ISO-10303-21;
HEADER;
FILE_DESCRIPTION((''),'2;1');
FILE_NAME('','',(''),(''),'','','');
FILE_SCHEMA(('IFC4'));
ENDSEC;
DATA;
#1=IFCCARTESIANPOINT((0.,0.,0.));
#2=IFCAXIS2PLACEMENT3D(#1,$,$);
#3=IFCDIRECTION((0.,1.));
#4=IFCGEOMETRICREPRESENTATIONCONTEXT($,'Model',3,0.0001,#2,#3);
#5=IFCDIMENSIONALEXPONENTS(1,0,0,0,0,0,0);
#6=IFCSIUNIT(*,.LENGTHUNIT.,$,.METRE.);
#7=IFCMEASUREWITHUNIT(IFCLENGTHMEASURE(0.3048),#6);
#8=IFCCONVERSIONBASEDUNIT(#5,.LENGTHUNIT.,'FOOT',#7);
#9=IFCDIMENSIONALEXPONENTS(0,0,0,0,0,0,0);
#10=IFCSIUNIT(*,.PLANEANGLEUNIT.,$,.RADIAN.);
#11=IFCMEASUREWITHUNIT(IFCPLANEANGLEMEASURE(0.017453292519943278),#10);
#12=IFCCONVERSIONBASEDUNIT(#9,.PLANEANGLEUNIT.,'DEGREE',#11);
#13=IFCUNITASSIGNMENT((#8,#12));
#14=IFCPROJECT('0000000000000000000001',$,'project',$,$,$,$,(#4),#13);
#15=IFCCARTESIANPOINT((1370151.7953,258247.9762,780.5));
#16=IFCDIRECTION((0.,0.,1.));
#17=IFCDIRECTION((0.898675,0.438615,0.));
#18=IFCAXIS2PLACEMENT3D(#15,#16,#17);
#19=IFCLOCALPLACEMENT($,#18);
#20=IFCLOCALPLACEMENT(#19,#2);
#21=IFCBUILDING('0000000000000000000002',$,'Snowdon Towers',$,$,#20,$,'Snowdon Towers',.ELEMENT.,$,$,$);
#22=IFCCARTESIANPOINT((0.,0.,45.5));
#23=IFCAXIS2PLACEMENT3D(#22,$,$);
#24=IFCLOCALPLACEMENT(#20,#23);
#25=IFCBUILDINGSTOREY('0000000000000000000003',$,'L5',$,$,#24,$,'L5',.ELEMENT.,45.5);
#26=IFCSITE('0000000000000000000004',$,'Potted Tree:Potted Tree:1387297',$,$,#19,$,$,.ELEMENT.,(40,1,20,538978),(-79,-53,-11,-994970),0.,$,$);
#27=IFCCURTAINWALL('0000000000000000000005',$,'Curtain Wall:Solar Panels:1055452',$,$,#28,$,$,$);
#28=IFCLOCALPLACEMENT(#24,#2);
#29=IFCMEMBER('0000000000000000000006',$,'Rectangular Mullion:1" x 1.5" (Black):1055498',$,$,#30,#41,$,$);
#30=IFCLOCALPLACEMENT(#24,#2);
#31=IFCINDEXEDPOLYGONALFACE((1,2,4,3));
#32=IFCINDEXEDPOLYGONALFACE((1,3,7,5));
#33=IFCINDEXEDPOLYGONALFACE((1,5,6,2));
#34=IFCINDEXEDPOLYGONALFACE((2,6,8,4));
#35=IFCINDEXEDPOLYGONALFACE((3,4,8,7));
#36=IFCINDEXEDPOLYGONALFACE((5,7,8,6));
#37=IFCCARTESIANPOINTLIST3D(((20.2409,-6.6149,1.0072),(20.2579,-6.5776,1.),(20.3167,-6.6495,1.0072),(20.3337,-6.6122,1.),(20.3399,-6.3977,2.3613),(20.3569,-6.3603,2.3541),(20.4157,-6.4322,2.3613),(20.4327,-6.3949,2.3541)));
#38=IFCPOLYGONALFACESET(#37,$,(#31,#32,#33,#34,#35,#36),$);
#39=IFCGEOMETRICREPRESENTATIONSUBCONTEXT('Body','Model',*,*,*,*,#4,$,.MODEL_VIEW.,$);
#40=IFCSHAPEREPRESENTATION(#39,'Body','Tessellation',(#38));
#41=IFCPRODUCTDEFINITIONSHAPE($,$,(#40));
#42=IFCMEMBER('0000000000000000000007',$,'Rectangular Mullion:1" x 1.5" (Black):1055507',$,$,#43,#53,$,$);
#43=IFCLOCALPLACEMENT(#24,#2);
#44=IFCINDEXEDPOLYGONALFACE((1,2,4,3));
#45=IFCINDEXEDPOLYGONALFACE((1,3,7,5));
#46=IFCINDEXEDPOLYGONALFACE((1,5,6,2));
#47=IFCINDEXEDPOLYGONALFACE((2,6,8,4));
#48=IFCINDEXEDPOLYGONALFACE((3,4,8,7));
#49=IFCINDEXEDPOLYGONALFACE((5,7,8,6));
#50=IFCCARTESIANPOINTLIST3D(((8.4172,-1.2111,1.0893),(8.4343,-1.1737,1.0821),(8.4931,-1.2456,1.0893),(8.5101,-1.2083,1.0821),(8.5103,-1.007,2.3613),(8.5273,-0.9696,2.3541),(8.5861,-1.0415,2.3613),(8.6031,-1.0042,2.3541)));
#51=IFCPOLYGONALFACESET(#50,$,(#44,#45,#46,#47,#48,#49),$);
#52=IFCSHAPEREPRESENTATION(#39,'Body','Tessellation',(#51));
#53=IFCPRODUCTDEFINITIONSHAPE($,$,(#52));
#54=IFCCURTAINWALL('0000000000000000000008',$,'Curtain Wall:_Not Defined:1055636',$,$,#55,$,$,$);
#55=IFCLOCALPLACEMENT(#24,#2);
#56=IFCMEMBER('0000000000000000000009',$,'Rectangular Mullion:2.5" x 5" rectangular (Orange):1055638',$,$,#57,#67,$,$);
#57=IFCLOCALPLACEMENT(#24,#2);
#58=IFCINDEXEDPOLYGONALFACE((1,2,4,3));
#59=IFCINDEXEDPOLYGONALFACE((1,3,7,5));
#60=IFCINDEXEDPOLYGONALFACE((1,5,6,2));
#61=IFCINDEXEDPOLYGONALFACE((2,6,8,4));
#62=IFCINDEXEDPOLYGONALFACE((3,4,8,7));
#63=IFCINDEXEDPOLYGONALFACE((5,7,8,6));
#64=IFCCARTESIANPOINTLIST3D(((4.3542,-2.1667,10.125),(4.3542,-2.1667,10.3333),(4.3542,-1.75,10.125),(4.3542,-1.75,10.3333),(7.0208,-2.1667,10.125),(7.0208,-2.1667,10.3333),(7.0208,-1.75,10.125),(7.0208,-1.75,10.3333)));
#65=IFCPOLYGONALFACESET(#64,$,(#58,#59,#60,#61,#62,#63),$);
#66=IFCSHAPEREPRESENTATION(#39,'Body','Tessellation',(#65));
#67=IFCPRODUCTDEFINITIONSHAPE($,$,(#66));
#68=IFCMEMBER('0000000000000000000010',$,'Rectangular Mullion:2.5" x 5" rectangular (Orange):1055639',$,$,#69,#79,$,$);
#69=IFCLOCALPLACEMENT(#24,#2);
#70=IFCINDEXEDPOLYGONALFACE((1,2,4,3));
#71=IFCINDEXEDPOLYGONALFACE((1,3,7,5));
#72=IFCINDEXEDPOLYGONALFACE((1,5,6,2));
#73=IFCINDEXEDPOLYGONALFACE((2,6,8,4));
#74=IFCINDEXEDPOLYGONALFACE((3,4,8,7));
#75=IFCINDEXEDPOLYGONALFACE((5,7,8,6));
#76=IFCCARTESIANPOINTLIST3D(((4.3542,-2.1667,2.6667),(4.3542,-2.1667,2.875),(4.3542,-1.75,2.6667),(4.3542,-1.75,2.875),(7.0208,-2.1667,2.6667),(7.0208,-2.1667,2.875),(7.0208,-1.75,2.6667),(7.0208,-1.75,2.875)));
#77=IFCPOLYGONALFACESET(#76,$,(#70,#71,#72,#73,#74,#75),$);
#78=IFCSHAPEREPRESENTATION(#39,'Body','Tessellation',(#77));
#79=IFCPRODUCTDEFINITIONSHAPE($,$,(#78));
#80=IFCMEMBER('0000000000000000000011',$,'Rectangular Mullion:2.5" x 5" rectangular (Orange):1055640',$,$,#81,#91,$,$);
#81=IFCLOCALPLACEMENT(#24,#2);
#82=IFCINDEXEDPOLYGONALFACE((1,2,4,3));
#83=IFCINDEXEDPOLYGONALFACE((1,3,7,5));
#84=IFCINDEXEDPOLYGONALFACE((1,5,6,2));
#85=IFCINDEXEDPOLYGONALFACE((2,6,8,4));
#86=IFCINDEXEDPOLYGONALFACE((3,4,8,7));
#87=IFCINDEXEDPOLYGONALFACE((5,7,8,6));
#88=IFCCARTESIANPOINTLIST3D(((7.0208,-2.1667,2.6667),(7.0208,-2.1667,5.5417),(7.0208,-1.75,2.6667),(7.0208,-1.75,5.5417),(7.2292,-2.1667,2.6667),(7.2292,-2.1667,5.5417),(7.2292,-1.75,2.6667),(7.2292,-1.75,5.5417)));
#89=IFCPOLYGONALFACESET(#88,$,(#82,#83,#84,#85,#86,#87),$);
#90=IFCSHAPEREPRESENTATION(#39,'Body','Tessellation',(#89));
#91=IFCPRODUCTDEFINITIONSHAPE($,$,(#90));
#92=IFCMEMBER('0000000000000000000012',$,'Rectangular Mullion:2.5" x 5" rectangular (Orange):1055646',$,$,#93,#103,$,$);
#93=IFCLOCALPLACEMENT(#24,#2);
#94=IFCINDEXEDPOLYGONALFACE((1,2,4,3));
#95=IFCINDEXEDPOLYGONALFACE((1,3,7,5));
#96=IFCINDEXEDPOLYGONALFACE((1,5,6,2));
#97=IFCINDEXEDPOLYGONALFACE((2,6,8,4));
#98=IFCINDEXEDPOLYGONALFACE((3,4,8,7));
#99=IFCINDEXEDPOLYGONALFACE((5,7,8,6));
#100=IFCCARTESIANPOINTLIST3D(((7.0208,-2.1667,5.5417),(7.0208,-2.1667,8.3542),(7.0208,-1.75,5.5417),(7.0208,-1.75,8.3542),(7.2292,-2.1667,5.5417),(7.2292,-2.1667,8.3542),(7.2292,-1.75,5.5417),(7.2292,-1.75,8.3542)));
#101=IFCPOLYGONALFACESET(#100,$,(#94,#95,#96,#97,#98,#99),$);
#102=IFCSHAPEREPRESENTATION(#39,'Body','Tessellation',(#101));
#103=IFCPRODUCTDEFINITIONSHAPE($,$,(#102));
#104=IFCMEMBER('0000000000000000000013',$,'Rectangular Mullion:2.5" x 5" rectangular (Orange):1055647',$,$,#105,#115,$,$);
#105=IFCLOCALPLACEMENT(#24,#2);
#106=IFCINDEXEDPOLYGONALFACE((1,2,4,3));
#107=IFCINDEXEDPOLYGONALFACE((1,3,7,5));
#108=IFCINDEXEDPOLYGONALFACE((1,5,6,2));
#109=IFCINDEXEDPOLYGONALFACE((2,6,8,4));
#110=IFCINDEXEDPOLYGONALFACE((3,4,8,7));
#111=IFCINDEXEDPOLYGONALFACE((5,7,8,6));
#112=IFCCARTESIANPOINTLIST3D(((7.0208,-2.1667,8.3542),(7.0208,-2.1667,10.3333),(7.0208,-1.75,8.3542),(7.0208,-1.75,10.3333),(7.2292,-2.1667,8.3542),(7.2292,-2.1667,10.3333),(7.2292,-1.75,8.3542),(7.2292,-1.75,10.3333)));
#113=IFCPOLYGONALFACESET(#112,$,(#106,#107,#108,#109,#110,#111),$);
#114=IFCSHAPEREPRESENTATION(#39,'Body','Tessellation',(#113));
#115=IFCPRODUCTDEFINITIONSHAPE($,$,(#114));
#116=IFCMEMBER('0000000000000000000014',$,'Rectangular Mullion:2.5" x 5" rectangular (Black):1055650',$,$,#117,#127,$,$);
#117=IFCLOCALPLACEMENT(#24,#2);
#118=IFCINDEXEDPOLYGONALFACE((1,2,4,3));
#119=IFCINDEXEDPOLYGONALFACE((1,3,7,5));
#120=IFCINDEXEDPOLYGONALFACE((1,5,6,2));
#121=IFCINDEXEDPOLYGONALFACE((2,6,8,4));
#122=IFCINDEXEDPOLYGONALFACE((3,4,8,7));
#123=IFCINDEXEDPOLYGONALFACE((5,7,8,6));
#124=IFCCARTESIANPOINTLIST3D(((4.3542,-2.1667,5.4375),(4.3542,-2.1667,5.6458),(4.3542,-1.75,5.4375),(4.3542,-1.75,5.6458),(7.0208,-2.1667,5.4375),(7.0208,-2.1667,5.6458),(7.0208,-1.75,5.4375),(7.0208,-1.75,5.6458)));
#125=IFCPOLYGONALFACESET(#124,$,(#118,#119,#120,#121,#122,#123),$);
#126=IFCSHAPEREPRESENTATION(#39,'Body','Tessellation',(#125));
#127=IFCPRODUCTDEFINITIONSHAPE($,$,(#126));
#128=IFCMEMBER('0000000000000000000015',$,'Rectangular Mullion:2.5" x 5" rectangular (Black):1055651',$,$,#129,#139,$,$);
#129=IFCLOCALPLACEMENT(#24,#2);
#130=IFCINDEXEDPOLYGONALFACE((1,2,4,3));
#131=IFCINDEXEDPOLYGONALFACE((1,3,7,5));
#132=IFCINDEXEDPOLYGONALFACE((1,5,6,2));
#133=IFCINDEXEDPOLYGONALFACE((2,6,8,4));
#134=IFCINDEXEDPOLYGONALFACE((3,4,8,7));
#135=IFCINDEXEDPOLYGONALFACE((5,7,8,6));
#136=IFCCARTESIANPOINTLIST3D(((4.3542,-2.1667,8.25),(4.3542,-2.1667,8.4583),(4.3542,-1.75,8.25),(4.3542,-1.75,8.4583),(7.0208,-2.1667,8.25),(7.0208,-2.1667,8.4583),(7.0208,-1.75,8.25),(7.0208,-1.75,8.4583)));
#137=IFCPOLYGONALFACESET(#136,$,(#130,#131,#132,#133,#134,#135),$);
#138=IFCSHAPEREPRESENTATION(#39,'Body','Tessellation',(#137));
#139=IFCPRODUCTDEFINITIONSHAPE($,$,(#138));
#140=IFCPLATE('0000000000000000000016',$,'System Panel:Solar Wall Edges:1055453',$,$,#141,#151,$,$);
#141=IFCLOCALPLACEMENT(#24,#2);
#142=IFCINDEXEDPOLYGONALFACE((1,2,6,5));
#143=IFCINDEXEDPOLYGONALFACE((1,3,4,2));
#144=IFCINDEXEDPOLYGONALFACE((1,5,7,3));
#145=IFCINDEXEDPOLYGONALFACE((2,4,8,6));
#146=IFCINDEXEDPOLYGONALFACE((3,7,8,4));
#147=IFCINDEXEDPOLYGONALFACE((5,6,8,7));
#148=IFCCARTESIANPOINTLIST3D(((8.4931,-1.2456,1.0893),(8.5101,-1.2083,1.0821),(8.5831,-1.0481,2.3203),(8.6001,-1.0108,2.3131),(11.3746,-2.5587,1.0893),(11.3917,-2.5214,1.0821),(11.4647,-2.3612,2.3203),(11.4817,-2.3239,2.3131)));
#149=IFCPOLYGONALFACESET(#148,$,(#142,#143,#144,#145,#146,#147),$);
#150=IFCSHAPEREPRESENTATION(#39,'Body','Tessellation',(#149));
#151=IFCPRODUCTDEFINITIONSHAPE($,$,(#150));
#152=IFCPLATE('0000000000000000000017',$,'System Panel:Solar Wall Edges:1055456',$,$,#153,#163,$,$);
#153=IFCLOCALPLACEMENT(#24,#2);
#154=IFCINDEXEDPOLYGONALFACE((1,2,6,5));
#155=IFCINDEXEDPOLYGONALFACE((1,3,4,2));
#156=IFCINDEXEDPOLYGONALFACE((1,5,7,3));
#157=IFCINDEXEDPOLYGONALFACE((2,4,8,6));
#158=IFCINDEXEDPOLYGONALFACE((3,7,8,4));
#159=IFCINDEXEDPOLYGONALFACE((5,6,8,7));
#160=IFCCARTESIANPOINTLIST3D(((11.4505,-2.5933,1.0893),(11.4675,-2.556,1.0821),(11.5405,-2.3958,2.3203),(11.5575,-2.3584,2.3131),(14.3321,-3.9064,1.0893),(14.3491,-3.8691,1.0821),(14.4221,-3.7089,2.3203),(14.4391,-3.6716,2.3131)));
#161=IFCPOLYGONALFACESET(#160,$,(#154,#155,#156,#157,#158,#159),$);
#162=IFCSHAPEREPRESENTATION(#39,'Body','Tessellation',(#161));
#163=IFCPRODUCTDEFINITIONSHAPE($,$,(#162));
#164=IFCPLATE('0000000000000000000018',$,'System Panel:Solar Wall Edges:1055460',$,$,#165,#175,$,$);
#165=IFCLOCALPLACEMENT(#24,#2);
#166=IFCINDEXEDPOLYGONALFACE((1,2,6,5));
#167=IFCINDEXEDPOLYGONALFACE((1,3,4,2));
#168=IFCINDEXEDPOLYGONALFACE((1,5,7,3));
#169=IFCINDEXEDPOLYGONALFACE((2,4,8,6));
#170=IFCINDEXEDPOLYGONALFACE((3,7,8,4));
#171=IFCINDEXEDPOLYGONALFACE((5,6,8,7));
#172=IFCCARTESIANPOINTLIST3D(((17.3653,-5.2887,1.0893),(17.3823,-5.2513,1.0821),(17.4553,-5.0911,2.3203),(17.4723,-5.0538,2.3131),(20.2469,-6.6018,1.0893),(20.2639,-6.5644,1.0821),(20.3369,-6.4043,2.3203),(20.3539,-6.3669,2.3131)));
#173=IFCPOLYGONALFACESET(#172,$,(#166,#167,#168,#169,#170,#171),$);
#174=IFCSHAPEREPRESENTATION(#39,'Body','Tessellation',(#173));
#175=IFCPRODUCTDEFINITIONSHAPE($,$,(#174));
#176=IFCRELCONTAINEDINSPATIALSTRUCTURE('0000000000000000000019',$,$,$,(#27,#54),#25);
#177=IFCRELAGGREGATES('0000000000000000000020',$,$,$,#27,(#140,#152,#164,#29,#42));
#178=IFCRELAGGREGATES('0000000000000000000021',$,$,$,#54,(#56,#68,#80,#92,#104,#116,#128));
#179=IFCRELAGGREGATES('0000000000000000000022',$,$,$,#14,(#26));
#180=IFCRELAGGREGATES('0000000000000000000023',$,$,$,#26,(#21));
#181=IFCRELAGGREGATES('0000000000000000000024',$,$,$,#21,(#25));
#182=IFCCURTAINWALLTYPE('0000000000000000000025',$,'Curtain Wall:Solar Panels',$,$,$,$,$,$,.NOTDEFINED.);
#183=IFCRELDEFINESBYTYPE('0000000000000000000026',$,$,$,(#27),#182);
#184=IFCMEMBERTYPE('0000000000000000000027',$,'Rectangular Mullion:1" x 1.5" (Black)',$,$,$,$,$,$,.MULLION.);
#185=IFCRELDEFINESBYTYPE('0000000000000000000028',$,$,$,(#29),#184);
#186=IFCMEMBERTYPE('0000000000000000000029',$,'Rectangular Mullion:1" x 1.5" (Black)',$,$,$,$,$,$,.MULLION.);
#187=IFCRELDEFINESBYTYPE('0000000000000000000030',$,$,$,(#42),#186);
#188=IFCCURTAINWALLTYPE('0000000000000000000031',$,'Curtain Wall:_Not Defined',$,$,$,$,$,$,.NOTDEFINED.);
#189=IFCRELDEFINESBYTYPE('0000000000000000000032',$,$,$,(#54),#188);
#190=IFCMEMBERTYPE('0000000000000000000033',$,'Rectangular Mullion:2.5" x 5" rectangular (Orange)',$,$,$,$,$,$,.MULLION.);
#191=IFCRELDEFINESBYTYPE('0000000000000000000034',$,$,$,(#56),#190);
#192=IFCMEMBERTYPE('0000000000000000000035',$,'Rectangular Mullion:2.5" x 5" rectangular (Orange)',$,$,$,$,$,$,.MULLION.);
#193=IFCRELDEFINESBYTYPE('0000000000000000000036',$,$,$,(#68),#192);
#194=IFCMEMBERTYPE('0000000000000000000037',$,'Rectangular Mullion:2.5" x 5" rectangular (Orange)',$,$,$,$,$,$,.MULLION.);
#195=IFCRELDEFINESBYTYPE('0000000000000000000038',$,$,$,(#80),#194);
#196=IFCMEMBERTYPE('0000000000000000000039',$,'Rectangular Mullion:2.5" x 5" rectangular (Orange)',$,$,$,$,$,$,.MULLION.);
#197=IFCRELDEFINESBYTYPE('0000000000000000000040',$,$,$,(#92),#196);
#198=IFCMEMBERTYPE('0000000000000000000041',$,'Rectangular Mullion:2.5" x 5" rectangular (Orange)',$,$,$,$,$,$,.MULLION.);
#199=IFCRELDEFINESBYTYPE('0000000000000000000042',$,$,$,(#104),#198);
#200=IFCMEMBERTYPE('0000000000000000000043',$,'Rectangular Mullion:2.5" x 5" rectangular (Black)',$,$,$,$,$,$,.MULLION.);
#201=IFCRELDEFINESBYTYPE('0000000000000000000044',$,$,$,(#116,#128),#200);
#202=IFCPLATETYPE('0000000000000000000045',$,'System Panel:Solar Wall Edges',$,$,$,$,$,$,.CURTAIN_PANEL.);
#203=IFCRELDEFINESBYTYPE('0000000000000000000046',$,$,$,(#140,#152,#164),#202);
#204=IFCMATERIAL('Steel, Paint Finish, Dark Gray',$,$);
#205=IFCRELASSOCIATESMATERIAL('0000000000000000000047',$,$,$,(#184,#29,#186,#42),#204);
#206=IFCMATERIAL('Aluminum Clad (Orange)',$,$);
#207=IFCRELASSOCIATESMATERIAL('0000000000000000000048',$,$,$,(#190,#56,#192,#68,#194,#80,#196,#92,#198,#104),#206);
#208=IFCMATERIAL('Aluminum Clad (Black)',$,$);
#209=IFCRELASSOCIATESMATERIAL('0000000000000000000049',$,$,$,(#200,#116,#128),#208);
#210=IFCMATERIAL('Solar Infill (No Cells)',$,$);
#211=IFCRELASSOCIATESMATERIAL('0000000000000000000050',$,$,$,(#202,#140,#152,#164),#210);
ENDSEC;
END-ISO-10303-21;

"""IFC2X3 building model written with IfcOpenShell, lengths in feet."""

from ifc_helpers import new_model, entity, si_unit, converted_unit, direction, frame, frame_2d, origin, origin_2d_with_axis, place, context, subcontext, project, spatial, rectangle, extrude, source, transform, mapped, material, type_object, type_shapes, element, aggregate, save


model = new_model("IFC2X3")

# Units and contexts
model_context = context("Model", 3, precision=0.0001, world=origin(), true_north=direction((0.0, 1.0)))
body_context = subcontext(model_context, "Body", "Model", "MODEL_VIEW")
ifc_project = project(units=[converted_unit("LENGTHUNIT", "FOOT", entity("IfcLengthMeasure", 0.3048), si_unit("LENGTHUNIT", "METRE"), dimensions=[1, 0, 0, 0, 0, 0, 0]), converted_unit("PLANEANGLEUNIT", "DEGREE", entity("IfcPlaneAngleMeasure", 0.017453292519943278), si_unit("PLANEANGLEUNIT", "RADIAN"), dimensions=[0, 0, 0, 0, 0, 0, 0])], contexts=[model_context])

# Site, building, storey
site_placement = place(None, frame((1370151.7953, 258247.9762, 780.5), z_axis=(0.0, 0.0, 1.0), x_axis=(0.898675, 0.438615, 0.0)))
site = spatial("IfcSite", under=ifc_project, at=site_placement, Name="Potted Tree:Potted Tree:1387297", CompositionType="ELEMENT", RefLatitude=(40, 1, 20, 538978), RefLongitude=(-79, -53, -11, -994970), RefElevation=0.0)
building_placement = place(site_placement, origin())
building = spatial("IfcBuilding", under=site, at=building_placement, Name="Snowdon Towers", LongName="Snowdon Towers", CompositionType="ELEMENT")
storey_placement = place(building_placement, frame((0.0, 0.0, 45.5)))
storey = spatial("IfcBuildingStorey", under=building, at=storey_placement, Name="L5", LongName="L5", CompositionType="ELEMENT", Elevation=45.5)

# Curtain walls, members
curtain_wall_type_1 = type_object("IfcCurtainWallType", Name="Curtain Wall:Solar Panels", PredefinedType="NOTDEFINED")
curtain_wall_1_placement = place(storey_placement, frame((0.0, 0.0, -45.5)))
curtain_wall_1 = element("IfcCurtainWall", 1, at=curtain_wall_1_placement, inside=storey, type_object=curtain_wall_type_1, Name="Curtain Wall:Solar Panels:1055452")
ifc_material_1 = material(Name="Steel, Paint Finish, Dark Gray")
ifc_material_2 = material(Name="Aluminum Clad (Orange)")
member_type_1 = type_object("IfcMemberType", Name="Rectangular Mullion:1\" x 1.5\" (Black)", PredefinedType="MULLION", material=ifc_material_1)
shared_shape_1 = source(origin(), body_context, "Body", "SweptSolid", [
    extrude(rectangle(XDim=0.0833, YDim=0.0417, at=frame_2d((0.0, 0.0), x_axis=(1.0, 0.0))), frame((-0.0417, 0.0208, -1.375), z_axis=(0.0, 0.0, 1.0), x_axis=(-1.0, 0.0, 0.0)), (0.0, 0.0, 1.0), 1.375),
])
type_shapes(member_type_1, [shared_shape_1])
member_1_placement = place(curtain_wall_1_placement, frame((20.3337, -6.6122, 46.5), z_axis=(-0.072007, -0.158015, -0.984808), x_axis=(0.909972, -0.414671, 0.0)))
member_1 = element("IfcMember", 2, at=member_1_placement, type_object=member_type_1, material=ifc_material_1, Name="Rectangular Mullion:1\" x 1.5\" (Black):1055498", context=body_context, shape_type="MappedRepresentation", body=[
    mapped(shared_shape_1, transform((0.0, 0.0, 0.0), scale=1.0)),
])
member_type_2 = type_object("IfcMemberType", Name="Rectangular Mullion:1\" x 1.5\" (Black)", PredefinedType="MULLION", material=ifc_material_1)
shared_shape_2 = source(origin(), body_context, "Body", "SweptSolid", [
    extrude(rectangle(XDim=0.0833, YDim=0.0417, at=origin_2d_with_axis()), frame((-0.0417, 0.0208, -1.2917), z_axis=(0.0, 0.0, 1.0), x_axis=(-1.0, 0.0, 0.0)), (0.0, 0.0, 1.0), 1.2917),
])
type_shapes(member_type_2, [shared_shape_2])
member_2_placement = place(curtain_wall_1_placement, frame((8.5273, -0.9696, 47.8541), z_axis=(0.072007, 0.158015, 0.984808), x_axis=(-0.909972, 0.414671, 0.0)))
member_2 = element("IfcMember", 3, at=member_2_placement, type_object=member_type_2, material=ifc_material_1, Name="Rectangular Mullion:1\" x 1.5\" (Black):1055507", context=body_context, shape_type="MappedRepresentation", body=[
    mapped(shared_shape_2, transform((0.0, 0.0, 0.0), scale=1.0)),
])
curtain_wall_type_2 = type_object("IfcCurtainWallType", Name="Curtain Wall:_Not Defined", PredefinedType="NOTDEFINED")
curtain_wall_2_placement = place(storey_placement, frame((0.0, 0.0, -45.5)))
curtain_wall_2 = element("IfcCurtainWall", 4, at=curtain_wall_2_placement, inside=storey, type_object=curtain_wall_type_2, Name="Curtain Wall:_Not Defined:1055636")
member_type_3 = type_object("IfcMemberType", Name="Rectangular Mullion:2.5\" x 5\" rectangular (Orange)", PredefinedType="MULLION", material=ifc_material_2)
shared_shape_3 = source(origin(), body_context, "Body", "SweptSolid", [
    extrude(rectangle(XDim=0.2083, YDim=0.4167, at=frame_2d((0.0, 0.0), x_axis=(1.0, 0.0))), frame((-0.1042, 0.0, -2.6667), z_axis=(0.0, 0.0, 1.0), x_axis=(-1.0, 0.0, 0.0)), (0.0, 0.0, 1.0), 2.6667),
])
type_shapes(member_type_3, [shared_shape_3])
member_3_placement = place(curtain_wall_2_placement, frame((7.0208, -1.9583, 55.8333), z_axis=(1.0, 0.0, 0.0), x_axis=(0.0, 0.0, 1.0)))
member_3 = element("IfcMember", 5, at=member_3_placement, type_object=member_type_3, material=ifc_material_2, Name="Rectangular Mullion:2.5\" x 5\" rectangular (Orange):1055638", context=body_context, shape_type="MappedRepresentation", body=[
    mapped(shared_shape_3, transform((0.0, 0.0, 0.0), scale=1.0)),
])
member_type_4 = type_object("IfcMemberType", Name="Rectangular Mullion:2.5\" x 5\" rectangular (Orange)", PredefinedType="MULLION", material=ifc_material_2)
shared_shape_4 = source(origin(), body_context, "Body", "SweptSolid", [
    extrude(rectangle(XDim=0.2083, YDim=0.4167, at=frame_2d((0.0, 0.0), x_axis=(1.0, 0.0))), frame((-0.1042, 0.0, -2.6667), z_axis=(0.0, 0.0, 1.0), x_axis=(-1.0, 0.0, 0.0)), (0.0, 0.0, 1.0), 2.6667),
])
type_shapes(member_type_4, [shared_shape_4])
member_4_placement = place(curtain_wall_2_placement, frame((4.3542, -1.9583, 48.1667), z_axis=(-1.0, 0.0, 0.0), x_axis=(0.0, 0.0, -1.0)))
member_4 = element("IfcMember", 6, at=member_4_placement, type_object=member_type_4, material=ifc_material_2, Name="Rectangular Mullion:2.5\" x 5\" rectangular (Orange):1055639", context=body_context, shape_type="MappedRepresentation", body=[
    mapped(shared_shape_4, transform((0.0, 0.0, 0.0), scale=1.0)),
])
member_type_5 = type_object("IfcMemberType", Name="Rectangular Mullion:2.5\" x 5\" rectangular (Orange)", PredefinedType="MULLION", material=ifc_material_2)
shared_shape_5 = source(origin(), body_context, "Body", "SweptSolid", [
    extrude(rectangle(XDim=0.2083, YDim=0.4167, at=frame_2d((0.0, 0.0), x_axis=(1.0, 0.0))), frame((-0.1042, 0.0, -2.875), z_axis=(0.0, 0.0, 1.0), x_axis=(-1.0, 0.0, 0.0)), (0.0, 0.0, 1.0), 2.875),
])
type_shapes(member_type_5, [shared_shape_5])
member_5_placement = place(curtain_wall_2_placement, frame((7.2292, -1.9583, 48.1667), z_axis=(0.0, 0.0, -1.0), x_axis=(1.0, 0.0, 0.0)))
member_5 = element("IfcMember", 7, at=member_5_placement, type_object=member_type_5, material=ifc_material_2, Name="Rectangular Mullion:2.5\" x 5\" rectangular (Orange):1055640", context=body_context, shape_type="MappedRepresentation", body=[
    mapped(shared_shape_5, transform((0.0, 0.0, 0.0), scale=1.0)),
])
member_type_6 = type_object("IfcMemberType", Name="Rectangular Mullion:2.5\" x 5\" rectangular (Orange)", PredefinedType="MULLION", material=ifc_material_2)
shared_shape_6 = source(origin(), body_context, "Body", "SweptSolid", [
    extrude(rectangle(XDim=0.2083, YDim=0.4167, at=frame_2d((0.0, 0.0), x_axis=(1.0, 0.0))), frame((-0.1042, 0.0, -2.8125), z_axis=(0.0, 0.0, 1.0), x_axis=(-1.0, 0.0, 0.0)), (0.0, 0.0, 1.0), 2.8125),
])
type_shapes(member_type_6, [shared_shape_6])
member_6_placement = place(curtain_wall_2_placement, frame((7.2292, -1.9583, 51.0417), z_axis=(0.0, 0.0, -1.0), x_axis=(1.0, 0.0, 0.0)))
member_6 = element("IfcMember", 8, at=member_6_placement, type_object=member_type_6, material=ifc_material_2, Name="Rectangular Mullion:2.5\" x 5\" rectangular (Orange):1055646", context=body_context, shape_type="MappedRepresentation", body=[
    mapped(shared_shape_6, transform((0.0, 0.0, 0.0), scale=1.0)),
])
member_type_7 = type_object("IfcMemberType", Name="Rectangular Mullion:2.5\" x 5\" rectangular (Orange)", PredefinedType="MULLION", material=ifc_material_2)
shared_shape_7 = source(origin(), body_context, "Body", "SweptSolid", [
    extrude(rectangle(XDim=0.2083, YDim=0.4167, at=frame_2d((0.0, 0.0), x_axis=(1.0, 0.0))), frame((-0.1042, 0.0, -1.9792), z_axis=(0.0, 0.0, 1.0), x_axis=(-1.0, 0.0, 0.0)), (0.0, 0.0, 1.0), 1.9792),
])
type_shapes(member_type_7, [shared_shape_7])
member_7_placement = place(curtain_wall_2_placement, frame((7.2292, -1.9583, 53.8542), z_axis=(0.0, 0.0, -1.0), x_axis=(1.0, 0.0, 0.0)))
member_7 = element("IfcMember", 9, at=member_7_placement, type_object=member_type_7, material=ifc_material_2, Name="Rectangular Mullion:2.5\" x 5\" rectangular (Orange):1055647", context=body_context, shape_type="MappedRepresentation", body=[
    mapped(shared_shape_7, transform((0.0, 0.0, 0.0), scale=1.0)),
])
ifc_material_3 = material(Name="Aluminum Clad (Black)")
member_type_8 = type_object("IfcMemberType", Name="Rectangular Mullion:2.5\" x 5\" rectangular (Black)", PredefinedType="MULLION", material=ifc_material_3)
shared_shape_8 = source(origin(), body_context, "Body", "SweptSolid", [
    extrude(rectangle(XDim=0.2083, YDim=0.4167, at=origin_2d_with_axis()), frame((0.0, 0.0, -2.6667), z_axis=(0.0, 0.0, 1.0), x_axis=(-1.0, 0.0, 0.0)), (0.0, 0.0, 1.0), 2.6667),
])
type_shapes(member_type_8, [shared_shape_8])
member_8_placement = place(curtain_wall_2_placement, frame((7.0208, -1.9583, 51.0417), z_axis=(1.0, 0.0, 0.0), x_axis=(0.0, 0.0, 1.0)))
member_8 = element("IfcMember", 10, at=member_8_placement, type_object=member_type_8, material=ifc_material_3, Name="Rectangular Mullion:2.5\" x 5\" rectangular (Black):1055650", context=body_context, shape_type="MappedRepresentation", body=[
    mapped(shared_shape_8, transform((0.0, 0.0, 0.0), scale=1.0)),
])
member_9_placement = place(curtain_wall_2_placement, frame((7.0208, -1.9583, 53.8542), z_axis=(1.0, 0.0, 0.0), x_axis=(0.0, 0.0, 1.0)))
member_9 = element("IfcMember", 11, at=member_9_placement, type_object=member_type_8, material=ifc_material_3, Name="Rectangular Mullion:2.5\" x 5\" rectangular (Black):1055651", context=body_context, shape_type="MappedRepresentation", body=[
    mapped(shared_shape_8, transform((0.0, 0.0, 0.0), scale=1.0)),
])

# Plates
ifc_material_4 = material(Name="Solar Infill (No Cells)")
plate_type_1 = type_object("IfcPlateType", Name="System Panel:Solar Wall Edges", PredefinedType="CURTAIN_PANEL", material=ifc_material_4)
shared_shape_9 = source(origin(), body_context, "Body", "SweptSolid", [
    extrude(rectangle(XDim=0.0417, YDim=3.1667, at=frame_2d((0.0, 0.0), x_axis=(1.0, 0.0))), frame((0.0, -0.0208, 0.0), z_axis=(0.0, 0.0, 1.0), x_axis=(0.0, 1.0, 0.0)), (0.0, 0.0, 1.0), 1.25),
])
type_shapes(plate_type_1, [shared_shape_9])
plate_1_placement = place(curtain_wall_1_placement, frame((9.9509, -1.8648, 46.5821), z_axis=(0.072007, 0.158015, 0.984808), x_axis=(0.909972, -0.414671, 0.0)))
plate_1 = element("IfcPlate", 12, at=plate_1_placement, type_object=plate_type_1, material=ifc_material_4, Name="System Panel:Solar Wall Edges:1055453", context=body_context, shape_type="MappedRepresentation", body=[
    mapped(shared_shape_9, transform((0.0, 0.0, 0.0), scale=1.0)),
])
plate_2_placement = place(curtain_wall_1_placement, frame((12.9083, -3.2125, 46.5821), z_axis=(0.072007, 0.158015, 0.984808), x_axis=(0.909972, -0.414671, 0.0)))
plate_2 = element("IfcPlate", 13, at=plate_2_placement, type_object=plate_type_1, material=ifc_material_4, Name="System Panel:Solar Wall Edges:1055456", context=body_context, shape_type="MappedRepresentation", body=[
    mapped(shared_shape_9, transform((0.0, 0.0, 0.0), scale=1.0)),
])
plate_3_placement = place(curtain_wall_1_placement, frame((18.8231, -5.9079, 46.5821), z_axis=(0.072007, 0.158015, 0.984808), x_axis=(0.909972, -0.414671, 0.0)))
plate_3 = element("IfcPlate", 14, at=plate_3_placement, type_object=plate_type_1, material=ifc_material_4, Name="System Panel:Solar Wall Edges:1055460", context=body_context, shape_type="MappedRepresentation", body=[
    mapped(shared_shape_9, transform((0.0, 0.0, 0.0), scale=1.0)),
])
aggregate(curtain_wall_1, [plate_1, plate_2, plate_3, member_1, member_2])
aggregate(curtain_wall_2, [member_3, member_4, member_5, member_6, member_7, member_8, member_9])

save(model, "model.ifc")
